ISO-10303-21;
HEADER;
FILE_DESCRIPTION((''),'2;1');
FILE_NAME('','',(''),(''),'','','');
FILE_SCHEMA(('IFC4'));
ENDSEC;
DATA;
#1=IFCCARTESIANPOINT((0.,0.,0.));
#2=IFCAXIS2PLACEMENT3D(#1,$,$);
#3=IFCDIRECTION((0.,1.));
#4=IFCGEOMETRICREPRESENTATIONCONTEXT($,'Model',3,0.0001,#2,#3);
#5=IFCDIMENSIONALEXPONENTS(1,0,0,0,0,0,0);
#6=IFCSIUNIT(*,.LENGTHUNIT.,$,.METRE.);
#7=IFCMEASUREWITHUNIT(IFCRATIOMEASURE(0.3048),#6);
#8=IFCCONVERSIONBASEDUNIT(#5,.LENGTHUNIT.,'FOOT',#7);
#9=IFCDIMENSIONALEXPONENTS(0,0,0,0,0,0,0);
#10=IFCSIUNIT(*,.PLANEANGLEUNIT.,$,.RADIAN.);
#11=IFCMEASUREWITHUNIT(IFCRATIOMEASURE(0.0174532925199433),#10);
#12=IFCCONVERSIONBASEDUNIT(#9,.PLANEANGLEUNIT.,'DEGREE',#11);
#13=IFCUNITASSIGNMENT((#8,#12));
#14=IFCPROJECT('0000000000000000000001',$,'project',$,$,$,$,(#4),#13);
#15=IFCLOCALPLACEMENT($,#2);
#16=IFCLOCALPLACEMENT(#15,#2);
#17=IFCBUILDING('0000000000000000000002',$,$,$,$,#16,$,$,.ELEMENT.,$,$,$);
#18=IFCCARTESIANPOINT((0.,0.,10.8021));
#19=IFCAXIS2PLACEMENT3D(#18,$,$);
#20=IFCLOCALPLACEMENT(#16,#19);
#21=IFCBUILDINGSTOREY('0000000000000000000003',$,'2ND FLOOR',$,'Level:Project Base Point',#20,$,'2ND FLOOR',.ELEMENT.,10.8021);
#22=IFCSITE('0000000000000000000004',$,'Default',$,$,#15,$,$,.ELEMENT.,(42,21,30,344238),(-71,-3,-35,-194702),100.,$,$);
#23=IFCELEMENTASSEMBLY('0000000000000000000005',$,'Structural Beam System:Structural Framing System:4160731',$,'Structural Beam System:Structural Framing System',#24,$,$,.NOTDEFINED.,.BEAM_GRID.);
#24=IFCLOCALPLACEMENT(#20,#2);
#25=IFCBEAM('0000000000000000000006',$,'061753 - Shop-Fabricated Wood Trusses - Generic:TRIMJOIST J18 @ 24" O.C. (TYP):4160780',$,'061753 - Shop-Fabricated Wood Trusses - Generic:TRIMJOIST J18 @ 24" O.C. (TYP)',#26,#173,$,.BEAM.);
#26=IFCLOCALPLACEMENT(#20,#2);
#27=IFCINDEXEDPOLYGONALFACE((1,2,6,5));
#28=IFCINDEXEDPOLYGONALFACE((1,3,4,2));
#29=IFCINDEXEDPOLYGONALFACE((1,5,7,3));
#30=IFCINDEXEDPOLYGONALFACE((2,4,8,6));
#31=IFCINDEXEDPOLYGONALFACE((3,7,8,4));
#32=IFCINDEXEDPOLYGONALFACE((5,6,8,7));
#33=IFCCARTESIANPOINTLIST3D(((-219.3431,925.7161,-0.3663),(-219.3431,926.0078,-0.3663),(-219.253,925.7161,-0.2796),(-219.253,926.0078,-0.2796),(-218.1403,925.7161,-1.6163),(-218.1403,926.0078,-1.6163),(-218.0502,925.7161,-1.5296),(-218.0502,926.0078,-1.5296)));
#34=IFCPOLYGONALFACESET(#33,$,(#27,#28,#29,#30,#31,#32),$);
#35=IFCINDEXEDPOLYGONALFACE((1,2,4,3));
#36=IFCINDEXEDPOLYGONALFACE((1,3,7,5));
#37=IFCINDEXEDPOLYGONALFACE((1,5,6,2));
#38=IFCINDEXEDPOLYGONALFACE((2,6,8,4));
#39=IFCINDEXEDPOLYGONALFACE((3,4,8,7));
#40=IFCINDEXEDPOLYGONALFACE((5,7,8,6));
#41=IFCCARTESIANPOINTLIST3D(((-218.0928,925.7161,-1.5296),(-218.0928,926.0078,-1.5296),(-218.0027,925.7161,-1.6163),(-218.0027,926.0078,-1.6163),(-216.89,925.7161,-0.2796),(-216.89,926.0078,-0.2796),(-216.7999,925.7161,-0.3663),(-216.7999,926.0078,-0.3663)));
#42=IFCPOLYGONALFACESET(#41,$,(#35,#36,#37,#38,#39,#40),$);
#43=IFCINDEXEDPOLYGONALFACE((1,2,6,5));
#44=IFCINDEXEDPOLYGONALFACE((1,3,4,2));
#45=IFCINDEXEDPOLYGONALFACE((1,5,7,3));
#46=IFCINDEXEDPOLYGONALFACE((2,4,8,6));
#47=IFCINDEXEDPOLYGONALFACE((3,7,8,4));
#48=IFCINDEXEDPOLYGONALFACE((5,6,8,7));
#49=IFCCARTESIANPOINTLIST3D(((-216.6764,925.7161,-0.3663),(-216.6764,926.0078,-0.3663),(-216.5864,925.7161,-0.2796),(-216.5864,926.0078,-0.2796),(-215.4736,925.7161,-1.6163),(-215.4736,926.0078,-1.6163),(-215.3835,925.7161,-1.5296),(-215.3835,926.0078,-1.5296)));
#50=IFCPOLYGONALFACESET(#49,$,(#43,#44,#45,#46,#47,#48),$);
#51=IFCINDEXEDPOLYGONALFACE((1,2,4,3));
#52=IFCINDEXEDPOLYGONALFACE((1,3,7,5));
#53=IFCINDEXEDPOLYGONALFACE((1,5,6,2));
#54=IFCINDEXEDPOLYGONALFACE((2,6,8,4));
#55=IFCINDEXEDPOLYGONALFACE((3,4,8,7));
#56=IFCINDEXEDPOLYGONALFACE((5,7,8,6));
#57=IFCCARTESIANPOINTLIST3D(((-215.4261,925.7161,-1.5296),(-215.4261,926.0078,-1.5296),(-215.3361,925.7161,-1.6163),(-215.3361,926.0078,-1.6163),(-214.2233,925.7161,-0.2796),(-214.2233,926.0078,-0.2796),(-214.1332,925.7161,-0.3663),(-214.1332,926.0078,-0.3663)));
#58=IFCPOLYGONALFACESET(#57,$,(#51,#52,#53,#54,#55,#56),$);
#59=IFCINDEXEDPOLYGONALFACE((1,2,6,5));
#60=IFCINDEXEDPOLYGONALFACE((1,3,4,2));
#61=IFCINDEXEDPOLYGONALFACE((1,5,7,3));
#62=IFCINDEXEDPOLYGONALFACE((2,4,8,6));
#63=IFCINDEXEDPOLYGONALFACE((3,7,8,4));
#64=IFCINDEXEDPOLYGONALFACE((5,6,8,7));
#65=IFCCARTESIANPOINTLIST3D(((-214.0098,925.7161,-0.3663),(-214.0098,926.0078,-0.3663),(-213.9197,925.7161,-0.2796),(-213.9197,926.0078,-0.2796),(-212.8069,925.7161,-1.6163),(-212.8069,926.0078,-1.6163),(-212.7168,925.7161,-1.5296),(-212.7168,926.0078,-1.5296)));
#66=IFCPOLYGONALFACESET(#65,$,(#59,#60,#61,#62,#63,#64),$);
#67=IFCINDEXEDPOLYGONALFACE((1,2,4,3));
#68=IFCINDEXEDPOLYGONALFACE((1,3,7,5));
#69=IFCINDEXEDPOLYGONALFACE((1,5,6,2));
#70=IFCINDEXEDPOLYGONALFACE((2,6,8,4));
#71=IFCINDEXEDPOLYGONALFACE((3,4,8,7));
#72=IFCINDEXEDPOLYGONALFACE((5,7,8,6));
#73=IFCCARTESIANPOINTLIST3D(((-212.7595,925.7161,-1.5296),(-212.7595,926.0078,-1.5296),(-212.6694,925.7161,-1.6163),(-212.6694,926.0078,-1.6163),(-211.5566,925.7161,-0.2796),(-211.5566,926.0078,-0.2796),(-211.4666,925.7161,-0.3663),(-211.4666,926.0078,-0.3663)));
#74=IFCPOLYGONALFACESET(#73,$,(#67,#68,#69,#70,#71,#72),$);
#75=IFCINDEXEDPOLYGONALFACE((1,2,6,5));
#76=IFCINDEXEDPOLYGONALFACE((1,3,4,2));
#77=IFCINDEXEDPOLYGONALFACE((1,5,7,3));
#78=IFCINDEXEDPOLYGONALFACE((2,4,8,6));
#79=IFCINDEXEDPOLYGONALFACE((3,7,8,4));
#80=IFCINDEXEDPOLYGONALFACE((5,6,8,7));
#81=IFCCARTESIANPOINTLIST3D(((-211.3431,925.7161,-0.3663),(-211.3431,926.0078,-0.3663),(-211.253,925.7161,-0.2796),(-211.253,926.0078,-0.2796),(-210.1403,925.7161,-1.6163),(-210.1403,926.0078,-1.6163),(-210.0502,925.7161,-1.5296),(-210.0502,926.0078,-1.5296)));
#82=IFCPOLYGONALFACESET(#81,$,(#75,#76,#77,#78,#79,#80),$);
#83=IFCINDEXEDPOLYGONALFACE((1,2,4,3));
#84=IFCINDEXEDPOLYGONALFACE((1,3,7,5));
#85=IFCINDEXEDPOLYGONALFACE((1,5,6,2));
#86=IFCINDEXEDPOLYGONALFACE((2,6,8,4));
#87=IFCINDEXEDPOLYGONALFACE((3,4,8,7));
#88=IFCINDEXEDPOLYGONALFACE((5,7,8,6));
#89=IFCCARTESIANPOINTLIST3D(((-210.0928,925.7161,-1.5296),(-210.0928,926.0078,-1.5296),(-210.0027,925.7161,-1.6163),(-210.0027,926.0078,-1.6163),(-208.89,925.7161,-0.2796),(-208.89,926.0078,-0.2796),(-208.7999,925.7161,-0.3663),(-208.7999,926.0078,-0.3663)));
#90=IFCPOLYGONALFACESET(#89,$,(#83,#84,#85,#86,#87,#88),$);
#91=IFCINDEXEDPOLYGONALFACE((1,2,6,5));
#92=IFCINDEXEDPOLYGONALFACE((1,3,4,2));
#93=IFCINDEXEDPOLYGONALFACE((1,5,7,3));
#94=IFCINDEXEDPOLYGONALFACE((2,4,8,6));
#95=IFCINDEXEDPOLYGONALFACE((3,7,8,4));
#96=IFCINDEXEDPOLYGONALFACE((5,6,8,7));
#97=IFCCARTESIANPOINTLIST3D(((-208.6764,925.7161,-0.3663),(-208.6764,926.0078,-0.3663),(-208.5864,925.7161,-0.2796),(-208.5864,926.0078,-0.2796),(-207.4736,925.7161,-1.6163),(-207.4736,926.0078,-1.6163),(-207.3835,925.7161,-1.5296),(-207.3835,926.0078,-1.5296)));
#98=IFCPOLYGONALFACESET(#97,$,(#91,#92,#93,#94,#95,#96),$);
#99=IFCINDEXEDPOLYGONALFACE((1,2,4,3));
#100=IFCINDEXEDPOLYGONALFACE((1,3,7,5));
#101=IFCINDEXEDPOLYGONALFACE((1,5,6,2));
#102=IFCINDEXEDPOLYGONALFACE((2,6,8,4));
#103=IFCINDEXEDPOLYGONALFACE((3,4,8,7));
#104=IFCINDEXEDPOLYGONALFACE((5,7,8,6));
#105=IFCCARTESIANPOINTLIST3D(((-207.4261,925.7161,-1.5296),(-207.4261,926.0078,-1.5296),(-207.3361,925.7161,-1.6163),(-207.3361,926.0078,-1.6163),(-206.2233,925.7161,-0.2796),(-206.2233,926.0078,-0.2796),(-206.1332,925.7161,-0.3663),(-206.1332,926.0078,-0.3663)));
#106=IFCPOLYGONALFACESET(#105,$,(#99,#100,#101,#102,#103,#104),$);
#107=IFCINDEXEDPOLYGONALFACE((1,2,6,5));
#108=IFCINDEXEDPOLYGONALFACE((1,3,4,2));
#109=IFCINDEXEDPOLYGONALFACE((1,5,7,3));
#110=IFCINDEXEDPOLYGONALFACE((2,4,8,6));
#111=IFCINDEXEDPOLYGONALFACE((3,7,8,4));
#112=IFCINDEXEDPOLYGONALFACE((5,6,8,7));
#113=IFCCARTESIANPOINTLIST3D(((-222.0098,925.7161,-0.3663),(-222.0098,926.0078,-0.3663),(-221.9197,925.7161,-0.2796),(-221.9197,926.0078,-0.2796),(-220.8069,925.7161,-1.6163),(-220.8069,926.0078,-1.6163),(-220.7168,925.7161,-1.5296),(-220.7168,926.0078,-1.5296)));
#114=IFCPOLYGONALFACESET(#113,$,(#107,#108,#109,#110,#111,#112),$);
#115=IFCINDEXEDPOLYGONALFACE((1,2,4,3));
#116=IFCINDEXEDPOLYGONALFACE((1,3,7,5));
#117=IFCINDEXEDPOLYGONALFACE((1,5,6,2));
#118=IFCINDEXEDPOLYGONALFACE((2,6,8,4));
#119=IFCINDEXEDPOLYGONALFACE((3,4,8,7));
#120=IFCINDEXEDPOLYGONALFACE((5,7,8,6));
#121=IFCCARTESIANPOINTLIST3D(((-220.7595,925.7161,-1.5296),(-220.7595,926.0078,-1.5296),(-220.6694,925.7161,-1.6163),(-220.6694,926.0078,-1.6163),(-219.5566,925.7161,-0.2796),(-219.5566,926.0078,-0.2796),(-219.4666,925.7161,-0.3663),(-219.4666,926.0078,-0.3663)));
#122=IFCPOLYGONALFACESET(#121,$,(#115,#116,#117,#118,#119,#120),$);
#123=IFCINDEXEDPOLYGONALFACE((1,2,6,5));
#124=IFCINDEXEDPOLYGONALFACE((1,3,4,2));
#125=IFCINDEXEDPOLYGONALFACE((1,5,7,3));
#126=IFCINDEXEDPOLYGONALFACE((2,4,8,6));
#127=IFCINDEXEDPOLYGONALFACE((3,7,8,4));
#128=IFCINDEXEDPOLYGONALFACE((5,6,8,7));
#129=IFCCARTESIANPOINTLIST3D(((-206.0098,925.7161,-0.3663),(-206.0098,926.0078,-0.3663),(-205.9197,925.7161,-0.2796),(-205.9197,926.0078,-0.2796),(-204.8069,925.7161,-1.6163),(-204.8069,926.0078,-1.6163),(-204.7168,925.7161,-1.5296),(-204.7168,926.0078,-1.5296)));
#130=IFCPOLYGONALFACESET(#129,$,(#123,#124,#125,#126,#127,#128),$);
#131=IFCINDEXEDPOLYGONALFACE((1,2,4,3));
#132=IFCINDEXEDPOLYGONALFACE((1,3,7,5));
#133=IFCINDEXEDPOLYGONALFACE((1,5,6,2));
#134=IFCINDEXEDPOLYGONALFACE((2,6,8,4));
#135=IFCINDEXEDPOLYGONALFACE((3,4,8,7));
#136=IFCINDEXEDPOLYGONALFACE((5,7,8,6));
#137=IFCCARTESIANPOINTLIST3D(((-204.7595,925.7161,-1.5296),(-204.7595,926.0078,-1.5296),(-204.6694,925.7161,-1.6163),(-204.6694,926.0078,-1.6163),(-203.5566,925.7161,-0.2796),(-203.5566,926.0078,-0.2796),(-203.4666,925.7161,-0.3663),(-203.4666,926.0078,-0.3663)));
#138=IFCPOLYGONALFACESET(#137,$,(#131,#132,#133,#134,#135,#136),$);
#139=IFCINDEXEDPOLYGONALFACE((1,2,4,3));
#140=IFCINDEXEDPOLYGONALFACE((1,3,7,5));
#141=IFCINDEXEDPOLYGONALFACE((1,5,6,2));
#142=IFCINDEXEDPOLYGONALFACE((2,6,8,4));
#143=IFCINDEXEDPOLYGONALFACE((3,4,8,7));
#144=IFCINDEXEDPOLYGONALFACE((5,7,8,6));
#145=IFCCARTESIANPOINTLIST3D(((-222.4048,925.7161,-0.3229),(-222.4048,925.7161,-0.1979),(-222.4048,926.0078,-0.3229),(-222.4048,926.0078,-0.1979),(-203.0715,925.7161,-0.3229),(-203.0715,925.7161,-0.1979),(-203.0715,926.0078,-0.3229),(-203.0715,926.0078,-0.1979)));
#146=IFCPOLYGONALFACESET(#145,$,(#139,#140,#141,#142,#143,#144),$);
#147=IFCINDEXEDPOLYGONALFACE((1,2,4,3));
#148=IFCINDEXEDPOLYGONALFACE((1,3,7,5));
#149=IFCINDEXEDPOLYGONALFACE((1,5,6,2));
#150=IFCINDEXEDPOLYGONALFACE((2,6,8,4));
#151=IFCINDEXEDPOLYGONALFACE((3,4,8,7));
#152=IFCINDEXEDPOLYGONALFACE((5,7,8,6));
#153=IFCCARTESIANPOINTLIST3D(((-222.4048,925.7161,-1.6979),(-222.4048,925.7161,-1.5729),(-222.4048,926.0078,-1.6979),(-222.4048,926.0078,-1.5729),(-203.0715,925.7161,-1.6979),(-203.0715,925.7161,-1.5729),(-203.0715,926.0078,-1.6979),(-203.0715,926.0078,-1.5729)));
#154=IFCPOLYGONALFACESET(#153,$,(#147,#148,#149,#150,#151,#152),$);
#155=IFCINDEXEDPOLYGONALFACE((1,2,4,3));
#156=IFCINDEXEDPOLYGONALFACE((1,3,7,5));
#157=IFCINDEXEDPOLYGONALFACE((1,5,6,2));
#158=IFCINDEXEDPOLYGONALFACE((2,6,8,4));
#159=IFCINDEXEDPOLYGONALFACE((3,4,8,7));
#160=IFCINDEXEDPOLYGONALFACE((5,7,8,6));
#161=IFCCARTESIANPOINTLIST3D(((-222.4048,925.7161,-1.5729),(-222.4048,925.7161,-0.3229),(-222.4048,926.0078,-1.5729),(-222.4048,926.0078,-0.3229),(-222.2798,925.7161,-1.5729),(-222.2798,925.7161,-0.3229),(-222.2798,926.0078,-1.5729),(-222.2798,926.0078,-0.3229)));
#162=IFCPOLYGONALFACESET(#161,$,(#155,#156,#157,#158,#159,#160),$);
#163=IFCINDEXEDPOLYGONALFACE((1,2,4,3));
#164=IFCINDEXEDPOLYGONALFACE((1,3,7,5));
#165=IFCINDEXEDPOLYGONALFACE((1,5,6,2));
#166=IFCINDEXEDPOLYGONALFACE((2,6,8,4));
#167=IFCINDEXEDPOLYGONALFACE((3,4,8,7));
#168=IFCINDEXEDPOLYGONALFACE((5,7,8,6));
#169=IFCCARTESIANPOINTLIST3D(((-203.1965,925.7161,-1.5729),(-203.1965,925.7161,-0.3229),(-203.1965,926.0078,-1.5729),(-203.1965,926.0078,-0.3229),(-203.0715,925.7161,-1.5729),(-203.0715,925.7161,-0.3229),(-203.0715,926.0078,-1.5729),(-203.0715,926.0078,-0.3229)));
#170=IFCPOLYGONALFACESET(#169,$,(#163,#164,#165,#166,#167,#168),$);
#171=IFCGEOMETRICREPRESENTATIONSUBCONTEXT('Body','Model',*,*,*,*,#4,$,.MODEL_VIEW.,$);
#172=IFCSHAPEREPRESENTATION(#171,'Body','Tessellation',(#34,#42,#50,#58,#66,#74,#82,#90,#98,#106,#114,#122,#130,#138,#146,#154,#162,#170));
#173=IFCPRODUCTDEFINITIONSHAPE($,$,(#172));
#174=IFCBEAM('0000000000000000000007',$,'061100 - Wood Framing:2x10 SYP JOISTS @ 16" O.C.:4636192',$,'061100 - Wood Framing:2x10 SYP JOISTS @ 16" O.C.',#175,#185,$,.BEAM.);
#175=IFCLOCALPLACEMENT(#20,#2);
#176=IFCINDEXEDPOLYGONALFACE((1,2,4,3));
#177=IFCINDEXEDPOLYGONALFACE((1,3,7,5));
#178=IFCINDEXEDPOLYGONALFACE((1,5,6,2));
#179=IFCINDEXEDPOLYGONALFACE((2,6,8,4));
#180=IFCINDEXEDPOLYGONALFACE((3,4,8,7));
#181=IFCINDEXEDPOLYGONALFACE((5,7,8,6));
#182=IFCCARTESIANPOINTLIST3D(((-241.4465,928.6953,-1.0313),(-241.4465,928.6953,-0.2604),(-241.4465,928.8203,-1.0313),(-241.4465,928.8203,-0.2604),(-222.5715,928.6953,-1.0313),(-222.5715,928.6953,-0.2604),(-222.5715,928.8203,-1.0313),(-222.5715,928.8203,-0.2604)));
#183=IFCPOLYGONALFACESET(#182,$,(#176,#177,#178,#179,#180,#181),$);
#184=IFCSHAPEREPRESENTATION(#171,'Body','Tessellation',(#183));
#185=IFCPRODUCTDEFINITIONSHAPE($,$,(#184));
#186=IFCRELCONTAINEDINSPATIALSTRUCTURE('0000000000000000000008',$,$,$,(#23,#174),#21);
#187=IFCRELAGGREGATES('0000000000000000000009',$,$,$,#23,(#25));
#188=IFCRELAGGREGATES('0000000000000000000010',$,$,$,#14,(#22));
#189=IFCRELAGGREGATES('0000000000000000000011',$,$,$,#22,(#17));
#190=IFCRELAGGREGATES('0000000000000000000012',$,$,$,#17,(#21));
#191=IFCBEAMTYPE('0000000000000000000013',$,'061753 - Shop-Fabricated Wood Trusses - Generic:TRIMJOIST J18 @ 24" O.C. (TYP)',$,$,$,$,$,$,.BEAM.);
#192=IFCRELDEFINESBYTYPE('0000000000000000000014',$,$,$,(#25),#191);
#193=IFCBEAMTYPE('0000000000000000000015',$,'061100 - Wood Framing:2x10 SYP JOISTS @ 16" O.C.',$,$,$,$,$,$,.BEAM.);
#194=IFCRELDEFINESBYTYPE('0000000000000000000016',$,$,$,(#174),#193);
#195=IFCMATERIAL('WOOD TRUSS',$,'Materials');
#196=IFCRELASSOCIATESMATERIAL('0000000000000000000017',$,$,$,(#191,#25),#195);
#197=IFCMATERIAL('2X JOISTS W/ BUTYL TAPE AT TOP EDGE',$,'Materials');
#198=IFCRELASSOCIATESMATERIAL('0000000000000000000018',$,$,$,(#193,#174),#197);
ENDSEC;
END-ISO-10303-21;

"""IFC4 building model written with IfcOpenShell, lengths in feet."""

from ifc_helpers import new_model, entity, si_unit, converted_unit, direction, frame, frame_2d, origin, origin_2d_with_axis, place, context, subcontext, project, spatial, rectangle, extrude, source, transform, mapped, material, material_profile, profile_set, profile_usage, type_object, type_shapes, element, aggregate, save


model = new_model("IFC4")

# Units and contexts
model_context = context("Model", 3, precision=0.0001, world=origin(), true_north=direction((0.0, 1.0)))
body_context = subcontext(model_context, "Body", "Model", "MODEL_VIEW")
ifc_project = project(units=[converted_unit("LENGTHUNIT", "FOOT", entity("IfcRatioMeasure", 0.3048), si_unit("LENGTHUNIT", "METRE"), dimensions=[1, 0, 0, 0, 0, 0, 0]), converted_unit("PLANEANGLEUNIT", "DEGREE", entity("IfcRatioMeasure", 0.0174532925199433), si_unit("PLANEANGLEUNIT", "RADIAN"), dimensions=[0, 0, 0, 0, 0, 0, 0])], contexts=[model_context])

# Site, building, storey
site_placement = place(None, origin())
site = spatial("IfcSite", under=ifc_project, at=site_placement, Name="Default", CompositionType="ELEMENT", RefLatitude=(42, 21, 30, 344238), RefLongitude=(-71, -3, -35, -194702), RefElevation=100.0)
building_placement = place(site_placement, origin())
building = spatial("IfcBuilding", under=site, at=building_placement, CompositionType="ELEMENT")
storey_placement = place(building_placement, frame((0.0, 0.0, 10.8021)))
storey = spatial("IfcBuildingStorey", under=building, at=storey_placement, Name="2ND FLOOR", ObjectType="Level:Project Base Point", LongName="2ND FLOOR", CompositionType="ELEMENT", Elevation=10.8021)

# Element assembly, beam
ifc_material_1 = material(Name="WOOD TRUSS", Category="Materials")
ifc_material_profile_1 = material_profile(ifc_material_1, rectangle(XDim=1.7347, YDim=0.125, at=frame_2d((0.0, 0.0), x_axis=(1.0, 0.0))), Name="TRIMJOIST J18 @ 24\" O.C. (TYP)")
ifc_material_profile_2 = material_profile(ifc_material_1, rectangle(XDim=1.7347, YDim=0.125, at=frame_2d((0.0, 0.0), x_axis=(1.0, 0.0))), Name="TRIMJOIST J18 @ 24\" O.C. (TYP)")
ifc_material_profile_3 = material_profile(ifc_material_1, rectangle(XDim=1.7347, YDim=0.125, at=frame_2d((0.0, 0.0), x_axis=(1.0, 0.0))), Name="TRIMJOIST J18 @ 24\" O.C. (TYP)")
ifc_material_profile_4 = material_profile(ifc_material_1, rectangle(XDim=1.7347, YDim=0.125, at=frame_2d((0.0, 0.0), x_axis=(1.0, 0.0))), Name="TRIMJOIST J18 @ 24\" O.C. (TYP)")
ifc_material_profile_5 = material_profile(ifc_material_1, rectangle(XDim=1.7347, YDim=0.125, at=frame_2d((0.0, 0.0), x_axis=(1.0, 0.0))), Name="TRIMJOIST J18 @ 24\" O.C. (TYP)")
ifc_material_profile_6 = material_profile(ifc_material_1, rectangle(XDim=1.7347, YDim=0.125, at=frame_2d((0.0, 0.0), x_axis=(1.0, 0.0))), Name="TRIMJOIST J18 @ 24\" O.C. (TYP)")
ifc_material_profile_7 = material_profile(ifc_material_1, rectangle(XDim=1.7347, YDim=0.125, at=frame_2d((0.0, 0.0), x_axis=(1.0, 0.0))), Name="TRIMJOIST J18 @ 24\" O.C. (TYP)")
ifc_material_profile_8 = material_profile(ifc_material_1, rectangle(XDim=1.7347, YDim=0.125, at=frame_2d((0.0, 0.0), x_axis=(1.0, 0.0))), Name="TRIMJOIST J18 @ 24\" O.C. (TYP)")
ifc_material_profile_9 = material_profile(ifc_material_1, rectangle(XDim=1.7347, YDim=0.125, at=frame_2d((0.0, 0.0), x_axis=(1.0, 0.0))), Name="TRIMJOIST J18 @ 24\" O.C. (TYP)")
ifc_material_profile_10 = material_profile(ifc_material_1, rectangle(XDim=1.7347, YDim=0.125, at=origin_2d_with_axis()), Name="TRIMJOIST J18 @ 24\" O.C. (TYP)")
ifc_material_profile_11 = material_profile(ifc_material_1, rectangle(XDim=0.125, YDim=0.2917, at=origin_2d_with_axis()), Name="TRIMJOIST J18 @ 24\" O.C. (TYP)")
ifc_material_profile_12 = material_profile(ifc_material_1, rectangle(XDim=0.125, YDim=0.2917, at=origin_2d_with_axis()), Name="TRIMJOIST J18 @ 24\" O.C. (TYP)")
ifc_material_profile_13 = material_profile(ifc_material_1, rectangle(XDim=1.25, YDim=0.2917, at=origin_2d_with_axis()), Name="TRIMJOIST J18 @ 24\" O.C. (TYP)")
ifc_material_profile_14 = material_profile(ifc_material_1, rectangle(XDim=1.25, YDim=0.2917, at=origin_2d_with_axis()), Name="TRIMJOIST J18 @ 24\" O.C. (TYP)")
ifc_profile_set_1 = profile_set([ifc_material_profile_1, ifc_material_profile_2, ifc_material_profile_3, ifc_material_profile_4, ifc_material_profile_5, ifc_material_profile_6, ifc_material_profile_7, ifc_material_profile_8, ifc_material_profile_9, ifc_material_profile_10, ifc_material_profile_11, ifc_material_profile_12, ifc_material_profile_13, ifc_material_profile_14], Name="TRIMJOIST J18 @ 24\" O.C. (TYP)")
beam_type_1 = type_object("IfcBeamType", Name="061753 - Shop-Fabricated Wood Trusses - Generic:TRIMJOIST J18 @ 24\" O.C. (TYP)", PredefinedType="BEAM", material=ifc_profile_set_1)
shared_shape_1 = source(origin(), body_context, "Body", "SweptSolid", [
    extrude(rectangle(XDim=1.7347, YDim=0.125, at=frame_2d((0.0, 0.0), x_axis=(1.0, 0.0))), frame((5.9585, -0.1458, 0.0), z_axis=(0.0, 1.0, 0.0), x_axis=(0.693383, 0.0, 0.720569)), (0.0, 0.0, 1.0), 0.2917),
    extrude(rectangle(XDim=1.7347, YDim=0.125, at=origin_2d_with_axis()), frame((4.7082, -0.1458, 0.0), z_axis=(0.0, 1.0, 0.0), x_axis=(0.693383, 0.0, -0.720569)), (0.0, 0.0, 1.0), 0.2917),
    extrude(rectangle(XDim=1.7347, YDim=0.125, at=frame_2d((0.0, 0.0), x_axis=(1.0, 0.0))), frame((3.2918, -0.1458, 0.0), z_axis=(0.0, 1.0, 0.0), x_axis=(0.693383, 0.0, 0.720569)), (0.0, 0.0, 1.0), 0.2917),
    extrude(rectangle(XDim=1.7347, YDim=0.125, at=frame_2d((0.0, 0.0), x_axis=(1.0, 0.0))), frame((2.0415, -0.1458, 0.0), z_axis=(0.0, 1.0, 0.0), x_axis=(0.693383, 0.0, -0.720569)), (0.0, 0.0, 1.0), 0.2917),
    extrude(rectangle(XDim=1.7347, YDim=0.125, at=frame_2d((0.0, 0.0), x_axis=(1.0, 0.0))), frame((0.6251, -0.1458, 0.0), z_axis=(0.0, 1.0, 0.0), x_axis=(0.693383, 0.0, 0.720569)), (0.0, 0.0, 1.0), 0.2917),
    extrude(rectangle(XDim=1.7347, YDim=0.125, at=frame_2d((0.0, 0.0), x_axis=(1.0, 0.0))), frame((-0.6251, -0.1458, 0.0), z_axis=(0.0, 1.0, 0.0), x_axis=(0.693383, 0.0, -0.720569)), (0.0, 0.0, 1.0), 0.2917),
    extrude(rectangle(XDim=1.7347, YDim=0.125, at=frame_2d((0.0, 0.0), x_axis=(1.0, 0.0))), frame((-2.0415, -0.1458, 0.0), z_axis=(0.0, 1.0, 0.0), x_axis=(0.693383, 0.0, 0.720569)), (0.0, 0.0, 1.0), 0.2917),
    extrude(rectangle(XDim=1.7347, YDim=0.125, at=origin_2d_with_axis()), frame((-3.2918, -0.1458, 0.0), z_axis=(0.0, 1.0, 0.0), x_axis=(0.693383, 0.0, -0.720569)), (0.0, 0.0, 1.0), 0.2917),
    extrude(rectangle(XDim=1.7347, YDim=0.125, at=frame_2d((0.0, 0.0), x_axis=(1.0, 0.0))), frame((-4.7082, -0.1458, 0.0), z_axis=(0.0, 1.0, 0.0), x_axis=(0.693383, 0.0, 0.720569)), (0.0, 0.0, 1.0), 0.2917),
    extrude(rectangle(XDim=1.7347, YDim=0.125, at=frame_2d((0.0, 0.0), x_axis=(1.0, 0.0))), frame((-5.9585, -0.1458, 0.0), z_axis=(0.0, 1.0, 0.0), x_axis=(0.693383, 0.0, -0.720569)), (0.0, 0.0, 1.0), 0.2917),
    extrude(rectangle(XDim=1.7347, YDim=0.125, at=frame_2d((0.0, 0.0), x_axis=(1.0, 0.0))), frame((8.6251, -0.1458, 0.0), z_axis=(0.0, 1.0, 0.0), x_axis=(0.693383, 0.0, 0.720569)), (0.0, 0.0, 1.0), 0.2917),
    extrude(rectangle(XDim=1.7347, YDim=0.125, at=origin_2d_with_axis()), frame((7.3749, -0.1458, 0.0), z_axis=(0.0, 1.0, 0.0), x_axis=(0.693383, 0.0, -0.720569)), (0.0, 0.0, 1.0), 0.2917),
    extrude(rectangle(XDim=1.7347, YDim=0.125, at=frame_2d((0.0, 0.0), x_axis=(1.0, 0.0))), frame((-7.3749, -0.1458, 0.0), z_axis=(0.0, 1.0, 0.0), x_axis=(0.693383, 0.0, 0.720569)), (0.0, 0.0, 1.0), 0.2917),
    extrude(rectangle(XDim=1.7347, YDim=0.125, at=origin_2d_with_axis()), frame((-8.6251, -0.1458, 0.0), z_axis=(0.0, 1.0, 0.0), x_axis=(0.693383, 0.0, -0.720569)), (0.0, 0.0, 1.0), 0.2917),
    extrude(rectangle(XDim=0.125, YDim=0.2917, at=origin_2d_with_axis()), frame((-9.6667, 0.0, 0.6875), z_axis=(1.0, 0.0, 0.0), x_axis=(0.0, 0.0, -1.0)), (0.0, 0.0, 1.0), 19.3333),
    extrude(rectangle(XDim=0.125, YDim=0.2917, at=origin_2d_with_axis()), frame((-9.6667, 0.0, -0.6875), z_axis=(1.0, 0.0, 0.0), x_axis=(0.0, 0.0, -1.0)), (0.0, 0.0, 1.0), 19.3333),
    extrude(rectangle(XDim=1.25, YDim=0.2917, at=origin_2d_with_axis()), frame((9.5417, 0.0, 0.0), z_axis=(1.0, 0.0, 0.0), x_axis=(0.0, 0.0, -1.0)), (0.0, 0.0, 1.0), 0.125),
    extrude(rectangle(XDim=1.25, YDim=0.2917, at=origin_2d_with_axis()), frame((-9.6667, 0.0, 0.0), z_axis=(1.0, 0.0, 0.0), x_axis=(0.0, 0.0, -1.0)), (0.0, 0.0, 1.0), 0.125),
])
type_shapes(beam_type_1, [shared_shape_1])
assembly_1_placement = place(storey_placement, origin())
assembly_1 = element("IfcElementAssembly", 1, at=assembly_1_placement, inside=storey, Name="Structural Beam System:Structural Framing System:4160731", ObjectType="Structural Beam System:Structural Framing System", AssemblyPlace="NOTDEFINED", PredefinedType="BEAM_GRID")
ifc_profile_usage_1 = profile_usage(ifc_profile_set_1, cardinal=8)
beam_1_placement = place(assembly_1_placement, frame((-212.7382, 925.8619, -0.9479), z_axis=(0.0, 0.0, 1.0), x_axis=(-1.0, 0.0, 0.0)))
beam_1 = element("IfcBeam", 2, at=beam_1_placement, type_object=beam_type_1, material=ifc_profile_usage_1, Name="061753 - Shop-Fabricated Wood Trusses - Generic:TRIMJOIST J18 @ 24\" O.C. (TYP):4160780", ObjectType="061753 - Shop-Fabricated Wood Trusses - Generic:TRIMJOIST J18 @ 24\" O.C. (TYP)", PredefinedType="BEAM", context=body_context, shape_type="MappedRepresentation", body=[
    mapped(shared_shape_1, transform((0.0, 0.0, 0.0), scale=1.0)),
])
aggregate(assembly_1, [beam_1])

# Beam
ifc_material_2 = material(Name="2X JOISTS W/ BUTYL TAPE AT TOP EDGE", Category="Materials")
ifc_material_profile_15 = material_profile(ifc_material_2, rectangle(XDim=0.7708, YDim=0.125, at=frame_2d((0.0, 0.0), x_axis=(1.0, 0.0))), Name="2x10 SYP JOISTS @ 16\" O.C.")
ifc_profile_set_2 = profile_set([ifc_material_profile_15], Name="2x10 SYP JOISTS @ 16\" O.C.")
ifc_profile_usage_2 = profile_usage(ifc_profile_set_2, cardinal=8)
beam_type_2 = type_object("IfcBeamType", Name="061100 - Wood Framing:2x10 SYP JOISTS @ 16\" O.C.", PredefinedType="BEAM", material=ifc_profile_set_2)
shared_shape_2 = source(origin(), body_context, "Body", "SweptSolid", [
    extrude(rectangle(XDim=0.7708, YDim=0.125, at=origin_2d_with_axis()), frame((-9.5, 0.0, 0.0), z_axis=(1.0, 0.0, 0.0), x_axis=(0.0, 0.0, -1.0)), (0.0, 0.0, 1.0), 18.875),
])
type_shapes(beam_type_2, [shared_shape_2])
beam_2_placement = place(storey_placement, frame((-232.0715, 928.7578, -0.6458), z_axis=(0.0, 0.0, 1.0), x_axis=(-1.0, 0.0, 0.0)))
element("IfcBeam", 3, at=beam_2_placement, inside=storey, type_object=beam_type_2, material=ifc_profile_usage_2, Name="061100 - Wood Framing:2x10 SYP JOISTS @ 16\" O.C.:4636192", ObjectType="061100 - Wood Framing:2x10 SYP JOISTS @ 16\" O.C.", PredefinedType="BEAM", context=body_context, shape_type="MappedRepresentation", body=[
    mapped(shared_shape_2, transform((0.0, 0.0, 0.0), scale=1.0)),
])

save(model, "model.ifc")
